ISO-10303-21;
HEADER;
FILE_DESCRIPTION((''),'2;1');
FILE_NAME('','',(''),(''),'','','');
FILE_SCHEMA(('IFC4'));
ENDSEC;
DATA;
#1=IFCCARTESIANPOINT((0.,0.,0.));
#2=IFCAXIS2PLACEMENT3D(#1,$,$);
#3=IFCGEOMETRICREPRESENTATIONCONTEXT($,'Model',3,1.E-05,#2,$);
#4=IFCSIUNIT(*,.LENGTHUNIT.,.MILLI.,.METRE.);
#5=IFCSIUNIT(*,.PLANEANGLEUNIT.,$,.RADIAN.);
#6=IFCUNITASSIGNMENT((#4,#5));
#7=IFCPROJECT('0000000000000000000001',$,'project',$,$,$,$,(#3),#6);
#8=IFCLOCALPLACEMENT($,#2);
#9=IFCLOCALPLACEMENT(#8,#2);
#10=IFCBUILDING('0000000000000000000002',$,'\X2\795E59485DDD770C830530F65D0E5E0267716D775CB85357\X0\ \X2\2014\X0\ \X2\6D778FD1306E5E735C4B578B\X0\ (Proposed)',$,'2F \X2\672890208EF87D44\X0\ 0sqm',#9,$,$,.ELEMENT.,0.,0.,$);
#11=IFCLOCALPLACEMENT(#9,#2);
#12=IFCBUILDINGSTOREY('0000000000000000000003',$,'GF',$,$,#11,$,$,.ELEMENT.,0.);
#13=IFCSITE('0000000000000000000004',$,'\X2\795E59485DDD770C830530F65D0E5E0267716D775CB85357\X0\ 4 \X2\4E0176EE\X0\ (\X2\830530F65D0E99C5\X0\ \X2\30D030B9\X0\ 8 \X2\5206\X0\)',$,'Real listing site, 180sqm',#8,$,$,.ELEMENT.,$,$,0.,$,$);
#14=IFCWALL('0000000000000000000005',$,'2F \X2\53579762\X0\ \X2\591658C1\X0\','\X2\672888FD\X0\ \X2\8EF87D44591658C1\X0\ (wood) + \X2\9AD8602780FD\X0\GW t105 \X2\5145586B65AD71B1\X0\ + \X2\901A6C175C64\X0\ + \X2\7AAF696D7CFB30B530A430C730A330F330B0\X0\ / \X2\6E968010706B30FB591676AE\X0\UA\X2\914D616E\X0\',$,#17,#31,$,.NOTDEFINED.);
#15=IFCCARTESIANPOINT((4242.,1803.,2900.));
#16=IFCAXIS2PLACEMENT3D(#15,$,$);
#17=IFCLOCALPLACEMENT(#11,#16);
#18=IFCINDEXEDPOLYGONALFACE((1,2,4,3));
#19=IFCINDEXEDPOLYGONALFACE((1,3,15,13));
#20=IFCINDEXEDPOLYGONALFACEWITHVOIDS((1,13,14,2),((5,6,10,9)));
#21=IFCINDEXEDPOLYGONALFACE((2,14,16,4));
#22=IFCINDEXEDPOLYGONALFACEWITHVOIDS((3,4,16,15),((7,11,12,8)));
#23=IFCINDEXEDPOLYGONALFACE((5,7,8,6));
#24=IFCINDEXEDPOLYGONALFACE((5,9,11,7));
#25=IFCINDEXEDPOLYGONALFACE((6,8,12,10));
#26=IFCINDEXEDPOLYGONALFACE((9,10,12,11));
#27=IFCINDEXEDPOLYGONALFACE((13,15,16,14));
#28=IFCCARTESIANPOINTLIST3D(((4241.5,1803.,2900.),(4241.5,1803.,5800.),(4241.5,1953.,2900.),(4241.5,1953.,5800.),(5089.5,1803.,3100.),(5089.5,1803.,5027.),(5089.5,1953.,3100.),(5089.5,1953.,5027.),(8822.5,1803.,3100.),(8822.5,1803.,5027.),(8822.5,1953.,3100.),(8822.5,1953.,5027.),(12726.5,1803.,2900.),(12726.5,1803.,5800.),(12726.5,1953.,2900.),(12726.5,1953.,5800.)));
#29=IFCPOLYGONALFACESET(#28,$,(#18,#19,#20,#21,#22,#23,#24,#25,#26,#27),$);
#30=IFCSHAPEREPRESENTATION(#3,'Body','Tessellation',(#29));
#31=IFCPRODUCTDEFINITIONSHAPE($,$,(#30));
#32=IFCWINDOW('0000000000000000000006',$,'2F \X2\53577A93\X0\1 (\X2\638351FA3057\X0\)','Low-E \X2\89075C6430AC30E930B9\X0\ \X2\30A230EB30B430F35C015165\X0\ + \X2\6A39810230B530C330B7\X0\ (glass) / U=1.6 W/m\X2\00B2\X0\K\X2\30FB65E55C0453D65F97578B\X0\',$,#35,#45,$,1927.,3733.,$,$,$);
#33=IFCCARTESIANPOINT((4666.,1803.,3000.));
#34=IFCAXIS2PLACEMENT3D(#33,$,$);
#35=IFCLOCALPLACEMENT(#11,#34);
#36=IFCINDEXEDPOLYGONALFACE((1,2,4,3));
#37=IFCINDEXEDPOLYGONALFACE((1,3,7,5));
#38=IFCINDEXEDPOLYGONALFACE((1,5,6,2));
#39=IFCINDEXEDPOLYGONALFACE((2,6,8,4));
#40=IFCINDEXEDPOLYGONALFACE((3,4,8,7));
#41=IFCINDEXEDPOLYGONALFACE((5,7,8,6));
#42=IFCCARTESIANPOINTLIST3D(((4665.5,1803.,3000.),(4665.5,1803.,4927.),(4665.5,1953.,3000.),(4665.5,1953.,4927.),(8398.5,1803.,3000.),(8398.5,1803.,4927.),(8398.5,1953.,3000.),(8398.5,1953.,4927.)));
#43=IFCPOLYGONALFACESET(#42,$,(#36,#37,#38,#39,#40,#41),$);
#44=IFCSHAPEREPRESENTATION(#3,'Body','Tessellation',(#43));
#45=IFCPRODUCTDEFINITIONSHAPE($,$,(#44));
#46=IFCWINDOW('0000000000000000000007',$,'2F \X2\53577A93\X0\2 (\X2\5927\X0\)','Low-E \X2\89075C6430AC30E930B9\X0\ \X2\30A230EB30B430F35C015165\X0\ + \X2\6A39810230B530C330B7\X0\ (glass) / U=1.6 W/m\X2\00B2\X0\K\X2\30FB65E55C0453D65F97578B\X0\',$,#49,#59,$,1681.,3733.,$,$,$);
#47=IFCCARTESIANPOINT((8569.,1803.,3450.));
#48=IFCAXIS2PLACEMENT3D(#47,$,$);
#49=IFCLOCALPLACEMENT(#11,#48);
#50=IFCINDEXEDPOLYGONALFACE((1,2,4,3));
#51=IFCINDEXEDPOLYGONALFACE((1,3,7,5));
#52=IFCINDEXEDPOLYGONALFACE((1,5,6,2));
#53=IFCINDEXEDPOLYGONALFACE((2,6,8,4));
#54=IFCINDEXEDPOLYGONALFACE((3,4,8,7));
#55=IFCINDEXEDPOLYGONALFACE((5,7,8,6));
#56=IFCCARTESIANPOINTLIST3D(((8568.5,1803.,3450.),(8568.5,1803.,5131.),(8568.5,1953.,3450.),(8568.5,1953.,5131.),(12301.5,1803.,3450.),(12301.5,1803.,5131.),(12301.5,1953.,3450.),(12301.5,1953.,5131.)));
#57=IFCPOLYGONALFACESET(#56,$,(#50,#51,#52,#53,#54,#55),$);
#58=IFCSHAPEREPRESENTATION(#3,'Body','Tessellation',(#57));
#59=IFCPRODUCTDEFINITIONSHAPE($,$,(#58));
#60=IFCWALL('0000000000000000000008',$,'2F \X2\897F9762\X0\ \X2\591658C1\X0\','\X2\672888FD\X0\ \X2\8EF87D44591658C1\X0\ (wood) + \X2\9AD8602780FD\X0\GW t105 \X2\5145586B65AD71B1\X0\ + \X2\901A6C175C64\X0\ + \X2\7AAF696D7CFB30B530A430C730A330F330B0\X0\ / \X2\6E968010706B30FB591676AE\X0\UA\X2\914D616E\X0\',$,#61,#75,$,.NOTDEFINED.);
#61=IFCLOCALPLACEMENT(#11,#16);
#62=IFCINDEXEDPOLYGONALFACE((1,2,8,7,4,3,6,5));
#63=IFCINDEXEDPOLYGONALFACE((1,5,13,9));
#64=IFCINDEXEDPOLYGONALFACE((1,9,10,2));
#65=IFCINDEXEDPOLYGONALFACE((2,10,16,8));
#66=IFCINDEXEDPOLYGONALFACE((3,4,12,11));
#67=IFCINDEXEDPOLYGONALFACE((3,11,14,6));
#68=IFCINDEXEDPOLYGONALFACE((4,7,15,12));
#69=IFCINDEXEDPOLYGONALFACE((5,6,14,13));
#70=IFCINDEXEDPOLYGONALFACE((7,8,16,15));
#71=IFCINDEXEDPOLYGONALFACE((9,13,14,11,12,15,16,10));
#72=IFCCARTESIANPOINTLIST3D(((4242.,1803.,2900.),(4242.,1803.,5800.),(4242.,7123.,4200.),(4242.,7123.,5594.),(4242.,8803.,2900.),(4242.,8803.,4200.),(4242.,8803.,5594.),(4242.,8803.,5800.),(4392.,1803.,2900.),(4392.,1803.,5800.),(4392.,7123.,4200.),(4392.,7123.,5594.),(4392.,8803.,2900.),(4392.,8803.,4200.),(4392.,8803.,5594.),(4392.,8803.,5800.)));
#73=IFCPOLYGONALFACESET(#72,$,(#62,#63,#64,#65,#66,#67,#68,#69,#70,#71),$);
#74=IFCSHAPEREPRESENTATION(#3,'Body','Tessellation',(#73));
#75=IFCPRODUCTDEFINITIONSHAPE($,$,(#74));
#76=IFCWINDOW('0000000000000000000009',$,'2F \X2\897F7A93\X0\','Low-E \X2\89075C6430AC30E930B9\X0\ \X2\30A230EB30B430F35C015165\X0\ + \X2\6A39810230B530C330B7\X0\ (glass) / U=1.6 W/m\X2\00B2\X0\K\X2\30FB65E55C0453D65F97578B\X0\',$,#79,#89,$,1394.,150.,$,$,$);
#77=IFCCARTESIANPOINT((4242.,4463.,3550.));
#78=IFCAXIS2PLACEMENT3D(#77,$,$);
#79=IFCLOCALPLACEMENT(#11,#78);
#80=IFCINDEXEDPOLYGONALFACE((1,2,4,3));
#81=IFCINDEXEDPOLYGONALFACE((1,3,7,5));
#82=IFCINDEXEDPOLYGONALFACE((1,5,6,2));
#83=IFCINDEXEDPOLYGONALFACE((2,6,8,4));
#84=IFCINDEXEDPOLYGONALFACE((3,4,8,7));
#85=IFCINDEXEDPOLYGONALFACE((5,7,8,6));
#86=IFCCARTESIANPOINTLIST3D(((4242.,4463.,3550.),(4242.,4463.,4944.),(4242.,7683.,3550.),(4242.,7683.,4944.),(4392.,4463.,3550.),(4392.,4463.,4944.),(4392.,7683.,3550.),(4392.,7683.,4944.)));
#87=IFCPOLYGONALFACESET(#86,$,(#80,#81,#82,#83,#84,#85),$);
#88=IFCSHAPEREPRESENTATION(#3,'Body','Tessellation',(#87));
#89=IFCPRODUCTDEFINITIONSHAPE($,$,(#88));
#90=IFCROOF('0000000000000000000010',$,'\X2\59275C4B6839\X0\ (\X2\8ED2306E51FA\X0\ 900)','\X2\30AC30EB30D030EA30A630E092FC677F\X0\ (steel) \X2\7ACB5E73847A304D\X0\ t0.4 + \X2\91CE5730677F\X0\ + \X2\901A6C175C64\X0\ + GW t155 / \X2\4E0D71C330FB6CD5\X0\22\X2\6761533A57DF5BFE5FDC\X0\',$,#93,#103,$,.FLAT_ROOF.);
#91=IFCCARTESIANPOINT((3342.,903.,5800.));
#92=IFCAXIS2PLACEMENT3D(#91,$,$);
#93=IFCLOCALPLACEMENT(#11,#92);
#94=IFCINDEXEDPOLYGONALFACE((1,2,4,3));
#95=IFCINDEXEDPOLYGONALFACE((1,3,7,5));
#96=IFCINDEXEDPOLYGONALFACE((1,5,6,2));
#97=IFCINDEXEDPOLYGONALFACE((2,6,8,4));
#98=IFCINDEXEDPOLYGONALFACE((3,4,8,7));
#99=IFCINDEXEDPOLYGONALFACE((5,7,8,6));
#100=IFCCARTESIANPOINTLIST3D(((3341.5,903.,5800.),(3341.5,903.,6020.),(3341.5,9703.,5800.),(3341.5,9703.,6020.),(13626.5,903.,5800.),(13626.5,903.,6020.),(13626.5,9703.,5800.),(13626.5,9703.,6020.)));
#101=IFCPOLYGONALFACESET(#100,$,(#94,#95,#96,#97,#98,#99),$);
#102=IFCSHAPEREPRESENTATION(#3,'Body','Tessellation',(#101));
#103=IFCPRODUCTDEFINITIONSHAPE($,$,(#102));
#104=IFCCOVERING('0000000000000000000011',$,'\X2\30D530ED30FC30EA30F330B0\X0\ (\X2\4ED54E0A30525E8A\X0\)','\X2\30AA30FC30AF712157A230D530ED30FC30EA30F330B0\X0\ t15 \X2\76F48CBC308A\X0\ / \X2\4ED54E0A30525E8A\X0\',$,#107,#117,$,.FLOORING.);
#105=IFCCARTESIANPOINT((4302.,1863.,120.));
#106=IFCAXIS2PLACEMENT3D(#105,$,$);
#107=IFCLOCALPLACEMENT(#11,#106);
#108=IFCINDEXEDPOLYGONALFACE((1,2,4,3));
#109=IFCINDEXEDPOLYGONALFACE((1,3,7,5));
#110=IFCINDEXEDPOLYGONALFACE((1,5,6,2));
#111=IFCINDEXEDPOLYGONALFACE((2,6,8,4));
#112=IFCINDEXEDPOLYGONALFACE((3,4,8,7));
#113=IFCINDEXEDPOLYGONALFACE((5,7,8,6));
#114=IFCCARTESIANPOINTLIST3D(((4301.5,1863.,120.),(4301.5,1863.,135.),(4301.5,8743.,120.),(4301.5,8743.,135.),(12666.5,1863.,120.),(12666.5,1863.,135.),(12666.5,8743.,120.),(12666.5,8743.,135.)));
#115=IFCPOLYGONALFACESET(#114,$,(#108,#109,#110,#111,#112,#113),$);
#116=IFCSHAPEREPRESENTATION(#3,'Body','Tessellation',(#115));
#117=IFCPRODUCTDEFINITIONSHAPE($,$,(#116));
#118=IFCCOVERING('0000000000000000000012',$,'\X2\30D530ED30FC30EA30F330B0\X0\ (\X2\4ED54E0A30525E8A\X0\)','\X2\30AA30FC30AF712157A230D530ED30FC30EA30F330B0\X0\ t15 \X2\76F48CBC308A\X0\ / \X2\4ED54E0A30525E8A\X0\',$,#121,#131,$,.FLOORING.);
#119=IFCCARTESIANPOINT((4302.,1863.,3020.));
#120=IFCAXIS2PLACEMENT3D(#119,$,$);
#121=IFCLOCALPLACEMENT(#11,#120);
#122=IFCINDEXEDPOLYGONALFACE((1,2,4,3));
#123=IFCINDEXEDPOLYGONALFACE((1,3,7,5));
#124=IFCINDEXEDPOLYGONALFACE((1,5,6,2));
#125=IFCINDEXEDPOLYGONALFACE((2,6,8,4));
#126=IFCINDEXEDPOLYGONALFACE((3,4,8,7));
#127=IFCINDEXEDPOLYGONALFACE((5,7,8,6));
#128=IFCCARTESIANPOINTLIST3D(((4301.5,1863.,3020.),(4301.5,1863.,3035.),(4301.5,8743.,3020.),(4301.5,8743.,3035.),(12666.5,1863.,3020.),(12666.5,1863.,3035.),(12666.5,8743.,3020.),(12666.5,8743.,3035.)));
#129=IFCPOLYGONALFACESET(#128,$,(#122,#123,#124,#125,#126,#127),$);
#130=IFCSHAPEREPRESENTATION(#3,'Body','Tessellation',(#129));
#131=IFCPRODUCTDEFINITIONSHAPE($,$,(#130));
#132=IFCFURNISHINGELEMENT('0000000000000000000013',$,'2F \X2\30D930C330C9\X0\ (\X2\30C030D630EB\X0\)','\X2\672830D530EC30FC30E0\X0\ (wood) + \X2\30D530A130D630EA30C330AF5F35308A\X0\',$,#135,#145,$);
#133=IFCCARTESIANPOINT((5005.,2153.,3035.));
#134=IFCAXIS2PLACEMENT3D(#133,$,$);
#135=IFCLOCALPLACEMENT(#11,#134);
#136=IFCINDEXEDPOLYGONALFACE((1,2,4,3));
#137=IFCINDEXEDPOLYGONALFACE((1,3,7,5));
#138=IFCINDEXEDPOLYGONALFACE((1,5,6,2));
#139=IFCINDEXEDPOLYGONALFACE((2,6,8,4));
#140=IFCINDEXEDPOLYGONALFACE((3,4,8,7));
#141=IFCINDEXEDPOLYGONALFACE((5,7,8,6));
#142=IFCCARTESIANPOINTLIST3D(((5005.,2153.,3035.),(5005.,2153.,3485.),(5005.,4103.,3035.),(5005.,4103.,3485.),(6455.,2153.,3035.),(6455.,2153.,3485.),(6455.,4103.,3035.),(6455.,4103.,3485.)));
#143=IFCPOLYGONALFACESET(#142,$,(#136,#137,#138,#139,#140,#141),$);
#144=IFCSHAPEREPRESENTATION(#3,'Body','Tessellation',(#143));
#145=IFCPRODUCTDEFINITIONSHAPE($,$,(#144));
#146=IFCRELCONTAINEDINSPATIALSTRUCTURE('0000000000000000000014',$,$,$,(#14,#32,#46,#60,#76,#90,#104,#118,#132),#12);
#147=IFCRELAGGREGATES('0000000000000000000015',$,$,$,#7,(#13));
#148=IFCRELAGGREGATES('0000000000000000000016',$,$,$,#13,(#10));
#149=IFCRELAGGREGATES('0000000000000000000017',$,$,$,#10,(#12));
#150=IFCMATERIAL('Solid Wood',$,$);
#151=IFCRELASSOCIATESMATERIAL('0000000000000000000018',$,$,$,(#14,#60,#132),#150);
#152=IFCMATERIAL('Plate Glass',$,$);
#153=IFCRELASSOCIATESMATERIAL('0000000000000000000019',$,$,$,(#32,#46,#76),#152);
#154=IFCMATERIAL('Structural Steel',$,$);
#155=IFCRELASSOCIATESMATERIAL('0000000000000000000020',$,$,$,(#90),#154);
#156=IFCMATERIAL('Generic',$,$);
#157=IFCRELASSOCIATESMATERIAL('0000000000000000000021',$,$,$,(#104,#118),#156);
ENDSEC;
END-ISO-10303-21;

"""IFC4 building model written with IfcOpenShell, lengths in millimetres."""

from ifc_helpers import new_model, si_unit, frame, frame_2d, origin, place, context, project, spatial, rectangle, extrude, material, element, fill, save


model = new_model("IFC4")

# Units and contexts
model_context = context("Model", 3, precision=1e-05, world=origin())
ifc_project = project(units=[si_unit("LENGTHUNIT", "METRE", prefix="MILLI"), si_unit("PLANEANGLEUNIT", "RADIAN")], contexts=[model_context])

# Site, building, storey
site_placement = place(None, origin())
site = spatial("IfcSite", under=ifc_project, at=site_placement, Name="神奈川県茅ヶ崎市東海岸南 4 丁目 (茅ヶ崎駅 バス 8 分)", ObjectType="Real listing site, 180sqm", CompositionType="ELEMENT", RefElevation=0.0)
building_placement = place(site_placement, origin())
building = spatial("IfcBuilding", under=site, at=building_placement, Name="神奈川県茅ヶ崎市東海岸南 — 海近の平屋型 (Proposed)", ObjectType="2F 木造軸組 0sqm", CompositionType="ELEMENT", ElevationOfRefHeight=0.0, ElevationOfTerrain=0.0)
storey_placement = place(building_placement, origin())
storey = spatial("IfcBuildingStorey", under=building, at=storey_placement, Name="GF", CompositionType="ELEMENT", Elevation=0.0)

# Shared definitions
ifc_material_1 = material(Name="Solid Wood")

# Shared definitions
ifc_material_2 = material(Name="Plate Glass")

# Wall, openings, windows
wall_1_placement = place(storey_placement, frame((4242.0, 1803.0, 2900.0)))
wall_1 = element("IfcWall", 1, at=wall_1_placement, inside=storey, material=ifc_material_1, Name="2F 南面 外壁", Description="木製 軸組外壁 (wood) + 高性能GW t105 充填断熱 + 通気層 + 窯業系サイディング / 準耐火・外皮UA配慮", PredefinedType="NOTDEFINED", context=model_context, shape_type="SweptSolid", body=[
    extrude(rectangle(XDim=8485.0, YDim=150.0, at=frame_2d((4242.0, 75.0))), frame((4242.0, 1803.0, 2900.0)), (0.0, 0.0, 1.0), 2900.0),
])
opening_1_placement = place(storey_placement, frame((4666.0, 1803.0, 3000.0)))
opening_1 = element("IfcOpeningElement", 2, at=opening_1_placement, cuts=wall_1, PredefinedType="NOTDEFINED", context=model_context, shape_type="SweptSolid", body=[
    extrude(rectangle(XDim=3733.0, YDim=150.0, at=frame_2d((1866.0, 75.0))), frame((4666.0, 1803.0, 3000.0)), (0.0, 0.0, 1.0), 1927.0),
])
opening_2_placement = place(storey_placement, frame((8569.0, 1803.0, 3450.0)))
opening_2 = element("IfcOpeningElement", 3, at=opening_2_placement, cuts=wall_1, PredefinedType="NOTDEFINED", context=model_context, shape_type="SweptSolid", body=[
    extrude(rectangle(XDim=3733.0, YDim=150.0, at=frame_2d((1866.0, 75.0))), frame((8569.0, 1803.0, 3450.0)), (0.0, 0.0, 1.0), 1681.0),
])
window_1_placement = place(storey_placement, frame((4666.0, 1803.0, 3000.0)))
window_1 = element("IfcWindow", 4, at=window_1_placement, inside=storey, material=ifc_material_2, Name="2F 南窓1 (掃出し)", Description="Low-E 複層ガラス アルゴン封入 + 樹脂サッシ (glass) / U=1.6 W/m²K・日射取得型", OverallHeight=1927.0, OverallWidth=3733.0, context=model_context, shape_type="SweptSolid", body=[
    extrude(rectangle(XDim=3733.0, YDim=150.0, at=frame_2d((1866.0, 75.0))), frame((4666.0, 1803.0, 3000.0)), (0.0, 0.0, 1.0), 1927.0),
])
fill(opening_1, window_1)
window_2_placement = place(storey_placement, frame((8569.0, 1803.0, 3450.0)))
window_2 = element("IfcWindow", 5, at=window_2_placement, inside=storey, material=ifc_material_2, Name="2F 南窓2 (大)", Description="Low-E 複層ガラス アルゴン封入 + 樹脂サッシ (glass) / U=1.6 W/m²K・日射取得型", OverallHeight=1681.0, OverallWidth=3733.0, context=model_context, shape_type="SweptSolid", body=[
    extrude(rectangle(XDim=3733.0, YDim=150.0, at=frame_2d((1866.0, 75.0))), frame((8569.0, 1803.0, 3450.0)), (0.0, 0.0, 1.0), 1681.0),
])
fill(opening_2, window_2)

# Wall, opening, window
wall_2_placement = place(storey_placement, frame((4242.0, 1803.0, 2900.0)))
wall_2 = element("IfcWall", 6, at=wall_2_placement, inside=storey, material=ifc_material_1, Name="2F 西面 外壁", Description="木製 軸組外壁 (wood) + 高性能GW t105 充填断熱 + 通気層 + 窯業系サイディング / 準耐火・外皮UA配慮", PredefinedType="NOTDEFINED", context=model_context, shape_type="SweptSolid", body=[
    extrude(rectangle(XDim=150.0, YDim=7000.0, at=frame_2d((75.0, 3500.0))), frame((4242.0, 1803.0, 2900.0)), (0.0, 0.0, 1.0), 2900.0),
])
opening_3_placement = place(storey_placement, frame((4242.0, 4463.0, 3550.0)))
opening_3 = element("IfcOpeningElement", 7, at=opening_3_placement, cuts=wall_2, PredefinedType="NOTDEFINED", context=model_context, shape_type="SweptSolid", body=[
    extrude(rectangle(XDim=150.0, YDim=3220.0, at=frame_2d((75.0, 1610.0))), frame((4242.0, 4463.0, 3550.0)), (0.0, 0.0, 1.0), 1394.0),
])
window_3_placement = place(storey_placement, frame((4242.0, 4463.0, 3550.0)))
window_3 = element("IfcWindow", 8, at=window_3_placement, inside=storey, material=ifc_material_2, Name="2F 西窓", Description="Low-E 複層ガラス アルゴン封入 + 樹脂サッシ (glass) / U=1.6 W/m²K・日射取得型", OverallHeight=1394.0, OverallWidth=150.0, context=model_context, shape_type="SweptSolid", body=[
    extrude(rectangle(XDim=150.0, YDim=3220.0, at=frame_2d((75.0, 1610.0))), frame((4242.0, 4463.0, 3550.0)), (0.0, 0.0, 1.0), 1394.0),
])
fill(opening_3, window_3)

# Roof
ifc_material_3 = material(Name="Structural Steel")
roof_placement = place(storey_placement, frame((3342.0, 903.0, 5800.0)))
element("IfcRoof", 9, at=roof_placement, inside=storey, material=ifc_material_3, Name="大屋根 (軒の出 900)", Description="ガルバリウム鋼板 (steel) 立平葺き t0.4 + 野地板 + 通気層 + GW t155 / 不燃・法22条区域対応", PredefinedType="FLAT_ROOF", context=model_context, shape_type="SweptSolid", body=[
    extrude(rectangle(XDim=10285.0, YDim=8800.0, at=frame_2d((5142.0, 4400.0))), frame((3342.0, 903.0, 5800.0)), (0.0, 0.0, 1.0), 220.0),
])

# Coverings
ifc_material_4 = material(Name="Generic")
covering_1_placement = place(storey_placement, frame((4302.0, 1863.0, 120.0)))
element("IfcCovering", 10, at=covering_1_placement, inside=storey, material=ifc_material_4, Name="フローリング (仕上げ床)", Description="オーク無垢フローリング t15 直貼り / 仕上げ床", PredefinedType="FLOORING", context=model_context, shape_type="SweptSolid", body=[
    extrude(rectangle(XDim=8365.0, YDim=6880.0, at=frame_2d((4182.0, 3440.0))), frame((4302.0, 1863.0, 120.0)), (0.0, 0.0, 1.0), 15.0),
])
covering_2_placement = place(storey_placement, frame((4302.0, 1863.0, 3020.0)))
element("IfcCovering", 11, at=covering_2_placement, inside=storey, material=ifc_material_4, Name="フローリング (仕上げ床)", Description="オーク無垢フローリング t15 直貼り / 仕上げ床", PredefinedType="FLOORING", context=model_context, shape_type="SweptSolid", body=[
    extrude(rectangle(XDim=8365.0, YDim=6880.0, at=frame_2d((4182.0, 3440.0))), frame((4302.0, 1863.0, 3020.0)), (0.0, 0.0, 1.0), 15.0),
])

# Furnishing element
furnishing_placement = place(storey_placement, frame((5005.0, 2153.0, 3035.0)))
element("IfcFurnishingElement", 12, at=furnishing_placement, inside=storey, material=ifc_material_1, Name="2F ベッド (ダブル)", Description="木フレーム (wood) + ファブリック張り", context=model_context, shape_type="SweptSolid", body=[
    extrude(rectangle(XDim=1450.0, YDim=1950.0, at=frame_2d((725.0, 975.0))), frame((5005.0, 2153.0, 3035.0)), (0.0, 0.0, 1.0), 450.0),
])

save(model, "model.ifc")
